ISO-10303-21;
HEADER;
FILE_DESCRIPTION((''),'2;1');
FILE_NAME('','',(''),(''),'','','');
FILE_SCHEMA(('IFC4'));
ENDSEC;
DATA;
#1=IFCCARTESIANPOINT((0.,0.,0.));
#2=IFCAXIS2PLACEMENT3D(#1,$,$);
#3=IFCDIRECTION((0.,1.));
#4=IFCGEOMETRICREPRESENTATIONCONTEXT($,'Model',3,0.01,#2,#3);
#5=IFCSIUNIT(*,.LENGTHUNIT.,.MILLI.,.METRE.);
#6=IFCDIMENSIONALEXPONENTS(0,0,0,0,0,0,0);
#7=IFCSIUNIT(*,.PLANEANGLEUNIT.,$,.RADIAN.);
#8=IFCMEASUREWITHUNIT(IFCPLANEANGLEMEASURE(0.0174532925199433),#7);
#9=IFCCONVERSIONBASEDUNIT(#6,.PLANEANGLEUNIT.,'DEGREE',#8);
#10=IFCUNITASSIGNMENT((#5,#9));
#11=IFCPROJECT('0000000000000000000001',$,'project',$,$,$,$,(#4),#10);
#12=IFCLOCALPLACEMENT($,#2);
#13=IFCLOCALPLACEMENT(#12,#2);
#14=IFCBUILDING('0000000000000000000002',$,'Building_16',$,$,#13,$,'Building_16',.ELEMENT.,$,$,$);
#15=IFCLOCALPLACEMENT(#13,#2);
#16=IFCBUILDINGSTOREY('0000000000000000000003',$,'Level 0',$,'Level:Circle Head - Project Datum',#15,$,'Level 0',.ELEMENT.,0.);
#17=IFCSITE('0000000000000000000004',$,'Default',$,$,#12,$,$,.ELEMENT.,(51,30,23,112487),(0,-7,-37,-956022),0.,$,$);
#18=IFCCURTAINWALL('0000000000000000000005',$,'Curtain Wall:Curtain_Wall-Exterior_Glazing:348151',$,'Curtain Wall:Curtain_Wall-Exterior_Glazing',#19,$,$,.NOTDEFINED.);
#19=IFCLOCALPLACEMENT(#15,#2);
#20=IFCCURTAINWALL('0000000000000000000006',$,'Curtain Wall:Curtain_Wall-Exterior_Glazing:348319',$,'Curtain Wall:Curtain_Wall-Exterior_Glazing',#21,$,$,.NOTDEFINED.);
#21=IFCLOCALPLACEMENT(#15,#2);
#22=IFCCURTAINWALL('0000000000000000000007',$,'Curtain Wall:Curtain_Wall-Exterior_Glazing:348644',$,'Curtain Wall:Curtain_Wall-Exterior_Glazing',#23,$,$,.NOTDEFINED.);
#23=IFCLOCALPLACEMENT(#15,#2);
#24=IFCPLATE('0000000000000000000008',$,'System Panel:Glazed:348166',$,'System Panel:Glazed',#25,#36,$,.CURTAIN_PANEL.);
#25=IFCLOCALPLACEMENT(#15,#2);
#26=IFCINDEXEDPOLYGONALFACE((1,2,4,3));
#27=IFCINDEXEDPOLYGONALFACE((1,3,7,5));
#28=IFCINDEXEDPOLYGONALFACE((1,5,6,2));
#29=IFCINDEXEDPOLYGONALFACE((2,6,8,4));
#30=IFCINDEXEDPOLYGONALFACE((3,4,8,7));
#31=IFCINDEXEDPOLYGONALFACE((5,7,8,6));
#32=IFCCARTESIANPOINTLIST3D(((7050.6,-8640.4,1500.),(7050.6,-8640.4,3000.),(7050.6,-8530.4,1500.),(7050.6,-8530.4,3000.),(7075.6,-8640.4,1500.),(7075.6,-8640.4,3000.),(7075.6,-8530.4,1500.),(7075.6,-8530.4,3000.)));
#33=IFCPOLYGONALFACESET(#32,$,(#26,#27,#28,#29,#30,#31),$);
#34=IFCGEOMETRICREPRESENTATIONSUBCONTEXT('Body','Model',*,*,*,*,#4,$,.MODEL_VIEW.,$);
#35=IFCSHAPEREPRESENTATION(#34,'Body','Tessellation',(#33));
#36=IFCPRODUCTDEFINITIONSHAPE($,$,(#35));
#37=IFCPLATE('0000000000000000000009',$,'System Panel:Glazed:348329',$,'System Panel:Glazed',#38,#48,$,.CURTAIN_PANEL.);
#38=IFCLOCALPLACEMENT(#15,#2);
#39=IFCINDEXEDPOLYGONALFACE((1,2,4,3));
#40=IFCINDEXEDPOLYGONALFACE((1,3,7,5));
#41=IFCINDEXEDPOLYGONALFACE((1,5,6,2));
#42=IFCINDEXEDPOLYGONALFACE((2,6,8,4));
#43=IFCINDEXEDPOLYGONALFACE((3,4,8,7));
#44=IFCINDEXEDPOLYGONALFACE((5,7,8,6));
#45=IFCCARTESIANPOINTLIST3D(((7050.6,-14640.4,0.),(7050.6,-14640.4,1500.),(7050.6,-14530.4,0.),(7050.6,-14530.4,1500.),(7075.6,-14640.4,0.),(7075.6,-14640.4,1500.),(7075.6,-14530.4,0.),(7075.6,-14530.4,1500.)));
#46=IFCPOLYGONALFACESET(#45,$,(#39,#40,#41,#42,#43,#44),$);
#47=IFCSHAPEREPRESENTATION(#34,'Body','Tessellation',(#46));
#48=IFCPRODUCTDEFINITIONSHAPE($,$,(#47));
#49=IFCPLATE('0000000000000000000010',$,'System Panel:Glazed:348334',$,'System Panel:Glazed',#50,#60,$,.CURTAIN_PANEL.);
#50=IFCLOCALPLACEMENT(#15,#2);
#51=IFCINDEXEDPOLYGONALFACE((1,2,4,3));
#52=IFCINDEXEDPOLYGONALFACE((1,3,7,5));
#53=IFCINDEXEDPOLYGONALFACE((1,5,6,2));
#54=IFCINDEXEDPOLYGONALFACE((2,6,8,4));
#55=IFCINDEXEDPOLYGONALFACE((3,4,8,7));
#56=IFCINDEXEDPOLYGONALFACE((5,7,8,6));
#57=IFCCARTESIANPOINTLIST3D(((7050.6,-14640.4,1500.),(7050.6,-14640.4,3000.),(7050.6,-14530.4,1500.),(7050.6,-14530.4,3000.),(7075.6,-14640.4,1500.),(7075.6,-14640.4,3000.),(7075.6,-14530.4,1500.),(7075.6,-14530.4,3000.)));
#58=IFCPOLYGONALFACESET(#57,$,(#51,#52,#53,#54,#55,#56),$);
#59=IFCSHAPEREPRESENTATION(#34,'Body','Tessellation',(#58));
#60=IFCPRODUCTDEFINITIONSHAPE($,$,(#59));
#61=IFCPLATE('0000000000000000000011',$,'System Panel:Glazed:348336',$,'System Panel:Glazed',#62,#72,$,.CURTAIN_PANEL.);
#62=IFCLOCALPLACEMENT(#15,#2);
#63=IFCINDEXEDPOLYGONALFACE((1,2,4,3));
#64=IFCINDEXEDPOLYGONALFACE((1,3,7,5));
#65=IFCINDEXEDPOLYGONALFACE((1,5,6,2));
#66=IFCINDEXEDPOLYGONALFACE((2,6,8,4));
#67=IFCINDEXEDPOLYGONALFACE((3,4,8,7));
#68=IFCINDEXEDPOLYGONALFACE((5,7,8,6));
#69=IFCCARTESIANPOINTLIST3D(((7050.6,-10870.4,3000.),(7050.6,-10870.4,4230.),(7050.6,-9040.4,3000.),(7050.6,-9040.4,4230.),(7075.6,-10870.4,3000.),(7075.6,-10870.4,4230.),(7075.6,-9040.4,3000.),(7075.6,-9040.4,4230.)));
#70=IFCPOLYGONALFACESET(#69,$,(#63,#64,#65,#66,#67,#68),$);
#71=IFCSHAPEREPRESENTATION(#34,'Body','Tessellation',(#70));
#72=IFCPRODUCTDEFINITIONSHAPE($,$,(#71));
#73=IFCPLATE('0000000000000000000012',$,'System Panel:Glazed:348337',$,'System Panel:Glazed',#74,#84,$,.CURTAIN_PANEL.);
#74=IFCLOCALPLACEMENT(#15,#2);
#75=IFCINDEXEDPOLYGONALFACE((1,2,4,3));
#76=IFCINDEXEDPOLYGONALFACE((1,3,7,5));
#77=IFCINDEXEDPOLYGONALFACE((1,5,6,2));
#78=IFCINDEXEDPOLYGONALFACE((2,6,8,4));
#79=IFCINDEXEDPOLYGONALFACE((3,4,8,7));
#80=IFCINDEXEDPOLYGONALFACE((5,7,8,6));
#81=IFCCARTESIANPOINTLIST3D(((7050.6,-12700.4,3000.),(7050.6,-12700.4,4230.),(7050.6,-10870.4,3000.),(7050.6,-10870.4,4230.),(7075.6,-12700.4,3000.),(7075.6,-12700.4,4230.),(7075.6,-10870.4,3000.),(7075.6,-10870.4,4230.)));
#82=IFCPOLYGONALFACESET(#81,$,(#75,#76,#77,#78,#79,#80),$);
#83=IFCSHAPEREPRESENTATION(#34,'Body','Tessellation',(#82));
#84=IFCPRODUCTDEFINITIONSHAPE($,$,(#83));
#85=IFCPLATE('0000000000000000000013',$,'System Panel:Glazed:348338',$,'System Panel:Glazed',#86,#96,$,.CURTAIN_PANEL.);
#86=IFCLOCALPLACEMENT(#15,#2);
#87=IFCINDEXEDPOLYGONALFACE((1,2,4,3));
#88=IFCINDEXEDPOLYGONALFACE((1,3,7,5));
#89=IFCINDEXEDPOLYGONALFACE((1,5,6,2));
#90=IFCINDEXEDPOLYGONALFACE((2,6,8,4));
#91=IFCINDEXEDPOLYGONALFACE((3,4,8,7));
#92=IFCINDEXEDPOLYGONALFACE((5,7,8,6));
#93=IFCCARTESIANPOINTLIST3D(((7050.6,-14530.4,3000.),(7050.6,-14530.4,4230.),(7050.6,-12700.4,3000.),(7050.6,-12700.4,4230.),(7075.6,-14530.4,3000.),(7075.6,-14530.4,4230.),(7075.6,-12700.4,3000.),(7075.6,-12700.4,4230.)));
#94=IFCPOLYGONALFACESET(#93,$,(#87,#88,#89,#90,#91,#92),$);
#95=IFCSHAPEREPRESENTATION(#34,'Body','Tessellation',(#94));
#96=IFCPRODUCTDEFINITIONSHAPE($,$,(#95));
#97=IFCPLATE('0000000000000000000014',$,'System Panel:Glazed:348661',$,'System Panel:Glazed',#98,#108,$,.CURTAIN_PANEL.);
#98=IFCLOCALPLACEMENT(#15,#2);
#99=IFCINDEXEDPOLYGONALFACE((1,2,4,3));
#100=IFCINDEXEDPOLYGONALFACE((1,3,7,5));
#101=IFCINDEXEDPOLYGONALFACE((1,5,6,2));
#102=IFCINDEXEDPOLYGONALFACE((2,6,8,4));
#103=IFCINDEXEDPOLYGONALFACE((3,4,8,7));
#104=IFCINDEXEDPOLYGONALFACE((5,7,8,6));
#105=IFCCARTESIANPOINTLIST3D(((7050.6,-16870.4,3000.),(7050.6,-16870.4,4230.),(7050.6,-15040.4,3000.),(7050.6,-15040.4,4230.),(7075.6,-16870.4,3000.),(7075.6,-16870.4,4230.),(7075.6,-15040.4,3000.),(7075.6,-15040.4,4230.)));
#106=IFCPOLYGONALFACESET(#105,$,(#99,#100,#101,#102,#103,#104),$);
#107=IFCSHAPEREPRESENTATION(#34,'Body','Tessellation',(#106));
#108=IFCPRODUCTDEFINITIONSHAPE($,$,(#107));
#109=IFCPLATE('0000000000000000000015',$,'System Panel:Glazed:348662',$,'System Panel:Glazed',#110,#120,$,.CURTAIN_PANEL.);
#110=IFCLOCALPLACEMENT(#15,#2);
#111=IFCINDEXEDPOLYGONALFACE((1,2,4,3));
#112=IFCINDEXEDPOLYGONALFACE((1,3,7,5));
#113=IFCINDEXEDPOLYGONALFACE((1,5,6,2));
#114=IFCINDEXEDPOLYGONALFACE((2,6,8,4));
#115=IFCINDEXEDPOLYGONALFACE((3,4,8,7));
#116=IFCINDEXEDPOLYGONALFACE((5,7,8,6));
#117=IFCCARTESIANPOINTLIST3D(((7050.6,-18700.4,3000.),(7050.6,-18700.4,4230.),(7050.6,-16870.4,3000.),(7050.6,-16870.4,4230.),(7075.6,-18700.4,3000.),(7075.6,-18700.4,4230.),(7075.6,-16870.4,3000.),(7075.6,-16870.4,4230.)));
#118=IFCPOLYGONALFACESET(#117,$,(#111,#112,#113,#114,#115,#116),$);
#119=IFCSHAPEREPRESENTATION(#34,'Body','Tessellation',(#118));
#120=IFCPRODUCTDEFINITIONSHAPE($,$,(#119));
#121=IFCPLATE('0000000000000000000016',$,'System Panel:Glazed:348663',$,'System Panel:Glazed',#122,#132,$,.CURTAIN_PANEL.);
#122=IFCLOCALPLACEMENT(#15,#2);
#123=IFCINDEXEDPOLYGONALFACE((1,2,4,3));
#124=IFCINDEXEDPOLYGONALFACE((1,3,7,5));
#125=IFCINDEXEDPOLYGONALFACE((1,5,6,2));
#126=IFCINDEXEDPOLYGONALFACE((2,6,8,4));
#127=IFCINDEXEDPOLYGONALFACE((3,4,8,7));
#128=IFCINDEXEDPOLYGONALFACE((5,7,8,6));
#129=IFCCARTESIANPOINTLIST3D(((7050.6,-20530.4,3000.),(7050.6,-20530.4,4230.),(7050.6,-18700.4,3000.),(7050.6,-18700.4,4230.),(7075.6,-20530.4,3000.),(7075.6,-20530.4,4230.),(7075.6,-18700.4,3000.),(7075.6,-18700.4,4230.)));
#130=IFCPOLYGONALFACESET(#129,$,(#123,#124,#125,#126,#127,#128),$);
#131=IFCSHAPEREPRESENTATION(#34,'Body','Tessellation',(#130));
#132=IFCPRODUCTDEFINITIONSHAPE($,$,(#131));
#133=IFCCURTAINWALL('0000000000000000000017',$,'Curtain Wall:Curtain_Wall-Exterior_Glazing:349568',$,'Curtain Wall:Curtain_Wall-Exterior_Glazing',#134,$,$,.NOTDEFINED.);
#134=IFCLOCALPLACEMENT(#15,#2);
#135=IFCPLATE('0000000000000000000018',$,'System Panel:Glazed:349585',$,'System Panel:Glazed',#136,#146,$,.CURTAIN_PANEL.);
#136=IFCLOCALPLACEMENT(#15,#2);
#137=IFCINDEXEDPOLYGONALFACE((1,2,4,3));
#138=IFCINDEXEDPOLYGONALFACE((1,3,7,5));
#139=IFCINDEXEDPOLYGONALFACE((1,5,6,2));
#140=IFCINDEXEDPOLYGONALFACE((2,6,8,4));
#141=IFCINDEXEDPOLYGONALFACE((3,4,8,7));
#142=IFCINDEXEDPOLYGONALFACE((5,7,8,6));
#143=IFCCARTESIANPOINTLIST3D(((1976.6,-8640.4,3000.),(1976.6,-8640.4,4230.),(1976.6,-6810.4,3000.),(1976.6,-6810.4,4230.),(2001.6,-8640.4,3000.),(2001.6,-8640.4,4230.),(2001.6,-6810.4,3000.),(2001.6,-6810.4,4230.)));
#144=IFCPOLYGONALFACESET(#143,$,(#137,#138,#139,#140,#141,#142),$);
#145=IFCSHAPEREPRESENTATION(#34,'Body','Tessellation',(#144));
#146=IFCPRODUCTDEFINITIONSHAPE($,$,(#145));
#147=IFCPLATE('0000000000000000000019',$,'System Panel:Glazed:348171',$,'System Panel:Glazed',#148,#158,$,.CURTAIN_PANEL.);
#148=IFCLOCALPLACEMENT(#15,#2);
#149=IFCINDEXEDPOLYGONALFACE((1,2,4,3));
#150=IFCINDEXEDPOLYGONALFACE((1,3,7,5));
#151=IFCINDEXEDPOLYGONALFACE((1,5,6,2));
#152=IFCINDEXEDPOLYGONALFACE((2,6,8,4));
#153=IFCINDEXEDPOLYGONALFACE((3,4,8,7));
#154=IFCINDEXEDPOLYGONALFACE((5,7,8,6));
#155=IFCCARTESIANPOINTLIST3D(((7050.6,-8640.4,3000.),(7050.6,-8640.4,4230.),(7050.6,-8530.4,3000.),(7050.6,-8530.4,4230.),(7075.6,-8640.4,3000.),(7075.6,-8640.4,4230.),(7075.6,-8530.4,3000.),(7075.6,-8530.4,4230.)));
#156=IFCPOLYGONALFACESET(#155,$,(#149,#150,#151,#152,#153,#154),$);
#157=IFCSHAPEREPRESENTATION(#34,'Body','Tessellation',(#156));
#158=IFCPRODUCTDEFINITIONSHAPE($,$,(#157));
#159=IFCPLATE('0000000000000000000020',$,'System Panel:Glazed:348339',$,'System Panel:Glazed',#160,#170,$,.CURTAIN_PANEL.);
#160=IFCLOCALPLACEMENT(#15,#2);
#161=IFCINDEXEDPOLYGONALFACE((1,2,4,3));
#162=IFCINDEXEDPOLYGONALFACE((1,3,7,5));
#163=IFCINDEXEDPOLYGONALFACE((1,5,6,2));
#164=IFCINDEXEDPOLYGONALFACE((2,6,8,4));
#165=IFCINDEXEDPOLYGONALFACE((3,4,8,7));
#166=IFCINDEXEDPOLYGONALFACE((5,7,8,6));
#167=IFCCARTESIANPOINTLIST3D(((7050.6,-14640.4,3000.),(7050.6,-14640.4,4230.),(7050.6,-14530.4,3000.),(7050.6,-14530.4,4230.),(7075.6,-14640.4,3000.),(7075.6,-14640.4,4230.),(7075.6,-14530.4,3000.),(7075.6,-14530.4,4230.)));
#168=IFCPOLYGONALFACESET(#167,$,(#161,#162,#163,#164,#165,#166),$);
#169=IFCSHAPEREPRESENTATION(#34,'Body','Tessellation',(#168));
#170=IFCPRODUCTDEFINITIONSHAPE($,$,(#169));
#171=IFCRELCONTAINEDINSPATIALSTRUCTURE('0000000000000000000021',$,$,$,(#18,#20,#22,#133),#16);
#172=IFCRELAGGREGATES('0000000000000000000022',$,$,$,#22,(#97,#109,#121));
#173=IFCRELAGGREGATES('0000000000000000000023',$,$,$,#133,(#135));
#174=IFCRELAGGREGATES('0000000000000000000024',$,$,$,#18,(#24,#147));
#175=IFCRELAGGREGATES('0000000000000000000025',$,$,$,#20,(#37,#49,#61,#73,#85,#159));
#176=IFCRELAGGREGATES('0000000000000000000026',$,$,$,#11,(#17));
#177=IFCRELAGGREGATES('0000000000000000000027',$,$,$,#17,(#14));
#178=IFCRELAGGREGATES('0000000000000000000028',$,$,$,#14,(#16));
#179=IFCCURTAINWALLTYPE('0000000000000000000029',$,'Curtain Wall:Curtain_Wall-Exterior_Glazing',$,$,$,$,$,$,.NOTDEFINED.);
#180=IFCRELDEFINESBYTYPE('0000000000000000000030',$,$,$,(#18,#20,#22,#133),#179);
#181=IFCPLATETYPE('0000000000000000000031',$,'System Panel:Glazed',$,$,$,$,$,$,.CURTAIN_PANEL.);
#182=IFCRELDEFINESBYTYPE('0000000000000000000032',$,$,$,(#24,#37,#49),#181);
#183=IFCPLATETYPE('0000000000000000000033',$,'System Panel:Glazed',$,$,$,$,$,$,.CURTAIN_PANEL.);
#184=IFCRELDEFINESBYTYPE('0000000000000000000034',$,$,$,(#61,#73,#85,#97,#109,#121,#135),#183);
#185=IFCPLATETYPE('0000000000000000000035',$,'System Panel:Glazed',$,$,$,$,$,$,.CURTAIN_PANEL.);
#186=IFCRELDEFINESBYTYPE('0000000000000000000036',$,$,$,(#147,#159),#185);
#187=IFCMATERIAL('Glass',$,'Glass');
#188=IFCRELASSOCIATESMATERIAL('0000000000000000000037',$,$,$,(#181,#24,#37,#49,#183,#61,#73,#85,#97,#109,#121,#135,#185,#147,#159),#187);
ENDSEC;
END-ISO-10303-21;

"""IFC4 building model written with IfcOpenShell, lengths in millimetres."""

from ifc_helpers import new_model, entity, si_unit, converted_unit, direction, frame, origin, place, context, subcontext, project, spatial, indexed_curve, outline, extrude, source, transform, mapped, material, type_object, type_shapes, element, aggregate, save


model = new_model("IFC4")

# Units and contexts
model_context = context("Model", 3, precision=0.01, world=origin(), true_north=direction((0.0, 1.0)))
body_context = subcontext(model_context, "Body", "Model", "MODEL_VIEW")
ifc_project = project(units=[si_unit("LENGTHUNIT", "METRE", prefix="MILLI"), converted_unit("PLANEANGLEUNIT", "DEGREE", entity("IfcPlaneAngleMeasure", 0.0174532925199433), si_unit("PLANEANGLEUNIT", "RADIAN"), dimensions=[0, 0, 0, 0, 0, 0, 0])], contexts=[model_context])

# Site, building, storey
site_placement = place(None, origin())
site = spatial("IfcSite", under=ifc_project, at=site_placement, Name="Default", CompositionType="ELEMENT", RefLatitude=(51, 30, 23, 112487), RefLongitude=(0, -7, -37, -956022), RefElevation=0.0)
building_placement = place(site_placement, origin())
building = spatial("IfcBuilding", under=site, at=building_placement, Name="Building_16", LongName="Building_16", CompositionType="ELEMENT")
storey_placement = place(building_placement, origin())
storey = spatial("IfcBuildingStorey", under=building, at=storey_placement, Name="Level 0", ObjectType="Level:Circle Head - Project Datum", LongName="Level 0", CompositionType="ELEMENT", Elevation=0.0)

# Curtain walls
curtain_wall_type = type_object("IfcCurtainWallType", Name="Curtain Wall:Curtain_Wall-Exterior_Glazing", PredefinedType="NOTDEFINED")
curtain_wall_1_placement = place(storey_placement, origin())
curtain_wall_1 = element("IfcCurtainWall", 1, at=curtain_wall_1_placement, inside=storey, type_object=curtain_wall_type, Name="Curtain Wall:Curtain_Wall-Exterior_Glazing:348151", ObjectType="Curtain Wall:Curtain_Wall-Exterior_Glazing", PredefinedType="NOTDEFINED")
ifc_material_1 = material(Name="Glass", Category="Glass")
curtain_wall_2_placement = place(storey_placement, origin())
curtain_wall_2 = element("IfcCurtainWall", 2, at=curtain_wall_2_placement, inside=storey, type_object=curtain_wall_type, Name="Curtain Wall:Curtain_Wall-Exterior_Glazing:348319", ObjectType="Curtain Wall:Curtain_Wall-Exterior_Glazing", PredefinedType="NOTDEFINED")
curtain_wall_3_placement = place(storey_placement, origin())
curtain_wall_3 = element("IfcCurtainWall", 3, at=curtain_wall_3_placement, inside=storey, type_object=curtain_wall_type, Name="Curtain Wall:Curtain_Wall-Exterior_Glazing:348644", ObjectType="Curtain Wall:Curtain_Wall-Exterior_Glazing", PredefinedType="NOTDEFINED")

# Plates
plate_type_1 = type_object("IfcPlateType", Name="System Panel:Glazed", PredefinedType="CURTAIN_PANEL", material=ifc_material_1)
shared_shape_1 = source(origin(), body_context, "Body", "SweptSolid", [
    extrude(outline(indexed_curve([(-12.5, -55.0), (12.5, -55.0), (12.5, 55.0), (-12.5, 55.0), (-12.5, -55.0)], self_intersect=False)), frame((0.0, 37.0, 0.0), z_axis=(0.0, 0.0, 1.0), x_axis=(0.0, 1.0, 0.0)), (0.0, 0.0, 1.0), 1500.0),
])
type_shapes(plate_type_1, [shared_shape_1])
plate_1_placement = place(curtain_wall_1_placement, frame((7026.1, -8585.4, 1500.0), z_axis=(0.0, 0.0, 1.0), x_axis=(0.0, -1.0, 0.0)))
plate_1 = element("IfcPlate", 4, at=plate_1_placement, type_object=plate_type_1, material=ifc_material_1, Name="System Panel:Glazed:348166", ObjectType="System Panel:Glazed", PredefinedType="CURTAIN_PANEL", context=body_context, shape_type="MappedRepresentation", body=[
    mapped(shared_shape_1, transform((0.0, 0.0, 0.0), scale=1.0)),
])
plate_2_placement = place(curtain_wall_2_placement, frame((7026.1, -14585.4, 0.0), z_axis=(0.0, 0.0, 1.0), x_axis=(0.0, -1.0, 0.0)))
plate_2 = element("IfcPlate", 5, at=plate_2_placement, type_object=plate_type_1, material=ifc_material_1, Name="System Panel:Glazed:348329", ObjectType="System Panel:Glazed", PredefinedType="CURTAIN_PANEL", context=body_context, shape_type="MappedRepresentation", body=[
    mapped(shared_shape_1, transform((0.0, 0.0, 0.0), scale=1.0)),
])
plate_3_placement = place(curtain_wall_2_placement, frame((7026.1, -14585.4, 1500.0), z_axis=(0.0, 0.0, 1.0), x_axis=(0.0, -1.0, 0.0)))
plate_3 = element("IfcPlate", 6, at=plate_3_placement, type_object=plate_type_1, material=ifc_material_1, Name="System Panel:Glazed:348334", ObjectType="System Panel:Glazed", PredefinedType="CURTAIN_PANEL", context=body_context, shape_type="MappedRepresentation", body=[
    mapped(shared_shape_1, transform((0.0, 0.0, 0.0), scale=1.0)),
])
plate_type_2 = type_object("IfcPlateType", Name="System Panel:Glazed", PredefinedType="CURTAIN_PANEL", material=ifc_material_1)
shared_shape_2 = source(origin(), body_context, "Body", "SweptSolid", [
    extrude(outline(indexed_curve([(-12.5, -915.0), (12.5, -915.0), (12.5, 915.0), (-12.5, 915.0), (-12.5, -915.0)], self_intersect=False)), frame((0.0, 37.0, 0.0), z_axis=(0.0, 0.0, 1.0), x_axis=(0.0, 1.0, 0.0)), (0.0, 0.0, 1.0), 1230.0),
])
type_shapes(plate_type_2, [shared_shape_2])
plate_4_placement = place(curtain_wall_2_placement, frame((7026.1, -9955.4, 3000.0), z_axis=(0.0, 0.0, 1.0), x_axis=(0.0, -1.0, 0.0)))
plate_4 = element("IfcPlate", 7, at=plate_4_placement, type_object=plate_type_2, material=ifc_material_1, Name="System Panel:Glazed:348336", ObjectType="System Panel:Glazed", PredefinedType="CURTAIN_PANEL", context=body_context, shape_type="MappedRepresentation", body=[
    mapped(shared_shape_2, transform((0.0, 0.0, 0.0), scale=1.0)),
])
plate_5_placement = place(curtain_wall_2_placement, frame((7026.1, -11785.4, 3000.0), z_axis=(0.0, 0.0, 1.0), x_axis=(0.0, -1.0, 0.0)))
plate_5 = element("IfcPlate", 8, at=plate_5_placement, type_object=plate_type_2, material=ifc_material_1, Name="System Panel:Glazed:348337", ObjectType="System Panel:Glazed", PredefinedType="CURTAIN_PANEL", context=body_context, shape_type="MappedRepresentation", body=[
    mapped(shared_shape_2, transform((0.0, 0.0, 0.0), scale=1.0)),
])
plate_6_placement = place(curtain_wall_2_placement, frame((7026.1, -13615.4, 3000.0), z_axis=(0.0, 0.0, 1.0), x_axis=(0.0, -1.0, 0.0)))
plate_6 = element("IfcPlate", 9, at=plate_6_placement, type_object=plate_type_2, material=ifc_material_1, Name="System Panel:Glazed:348338", ObjectType="System Panel:Glazed", PredefinedType="CURTAIN_PANEL", context=body_context, shape_type="MappedRepresentation", body=[
    mapped(shared_shape_2, transform((0.0, 0.0, 0.0), scale=1.0)),
])
plate_7_placement = place(curtain_wall_3_placement, frame((7026.1, -15955.4, 3000.0), z_axis=(0.0, 0.0, 1.0), x_axis=(0.0, -1.0, 0.0)))
plate_7 = element("IfcPlate", 10, at=plate_7_placement, type_object=plate_type_2, material=ifc_material_1, Name="System Panel:Glazed:348661", ObjectType="System Panel:Glazed", PredefinedType="CURTAIN_PANEL", context=body_context, shape_type="MappedRepresentation", body=[
    mapped(shared_shape_2, transform((0.0, 0.0, 0.0), scale=1.0)),
])
plate_8_placement = place(curtain_wall_3_placement, frame((7026.1, -17785.4, 3000.0), z_axis=(0.0, 0.0, 1.0), x_axis=(0.0, -1.0, 0.0)))
plate_8 = element("IfcPlate", 11, at=plate_8_placement, type_object=plate_type_2, material=ifc_material_1, Name="System Panel:Glazed:348662", ObjectType="System Panel:Glazed", PredefinedType="CURTAIN_PANEL", context=body_context, shape_type="MappedRepresentation", body=[
    mapped(shared_shape_2, transform((0.0, 0.0, 0.0), scale=1.0)),
])
plate_9_placement = place(curtain_wall_3_placement, frame((7026.1, -19615.4, 3000.0), z_axis=(0.0, 0.0, 1.0), x_axis=(0.0, -1.0, 0.0)))
plate_9 = element("IfcPlate", 12, at=plate_9_placement, type_object=plate_type_2, material=ifc_material_1, Name="System Panel:Glazed:348663", ObjectType="System Panel:Glazed", PredefinedType="CURTAIN_PANEL", context=body_context, shape_type="MappedRepresentation", body=[
    mapped(shared_shape_2, transform((0.0, 0.0, 0.0), scale=1.0)),
])
aggregate(curtain_wall_3, [plate_7, plate_8, plate_9])

# Curtain wall, plate
curtain_wall_4_placement = place(storey_placement, origin())
curtain_wall_4 = element("IfcCurtainWall", 13, at=curtain_wall_4_placement, inside=storey, type_object=curtain_wall_type, Name="Curtain Wall:Curtain_Wall-Exterior_Glazing:349568", ObjectType="Curtain Wall:Curtain_Wall-Exterior_Glazing", PredefinedType="NOTDEFINED")
plate_10_placement = place(curtain_wall_4_placement, frame((2026.1, -7725.4, 3000.0), z_axis=(0.0, 0.0, 1.0), x_axis=(0.0, 1.0, 0.0)))
plate_10 = element("IfcPlate", 14, at=plate_10_placement, type_object=plate_type_2, material=ifc_material_1, Name="System Panel:Glazed:349585", ObjectType="System Panel:Glazed", PredefinedType="CURTAIN_PANEL", context=body_context, shape_type="MappedRepresentation", body=[
    mapped(shared_shape_2, transform((0.0, 0.0, 0.0), scale=1.0)),
])
aggregate(curtain_wall_4, [plate_10])

# Plates
plate_type_3 = type_object("IfcPlateType", Name="System Panel:Glazed", PredefinedType="CURTAIN_PANEL", material=ifc_material_1)
shared_shape_3 = source(origin(), body_context, "Body", "SweptSolid", [
    extrude(outline(indexed_curve([(-12.5, -55.0), (12.5, -55.0), (12.5, 55.0), (-12.5, 55.0), (-12.5, -55.0)], self_intersect=False)), frame((0.0, 37.0, 0.0), z_axis=(0.0, 0.0, 1.0), x_axis=(0.0, 1.0, 0.0)), (0.0, 0.0, 1.0), 1230.0),
])
type_shapes(plate_type_3, [shared_shape_3])
plate_11_placement = place(curtain_wall_1_placement, frame((7026.1, -8585.4, 3000.0), z_axis=(0.0, 0.0, 1.0), x_axis=(0.0, -1.0, 0.0)))
plate_11 = element("IfcPlate", 15, at=plate_11_placement, type_object=plate_type_3, material=ifc_material_1, Name="System Panel:Glazed:348171", ObjectType="System Panel:Glazed", PredefinedType="CURTAIN_PANEL", context=body_context, shape_type="MappedRepresentation", body=[
    mapped(shared_shape_3, transform((0.0, 0.0, 0.0), scale=1.0)),
])
aggregate(curtain_wall_1, [plate_1, plate_11])
plate_12_placement = place(curtain_wall_2_placement, frame((7026.1, -14585.4, 3000.0), z_axis=(0.0, 0.0, 1.0), x_axis=(0.0, -1.0, 0.0)))
plate_12 = element("IfcPlate", 16, at=plate_12_placement, type_object=plate_type_3, material=ifc_material_1, Name="System Panel:Glazed:348339", ObjectType="System Panel:Glazed", PredefinedType="CURTAIN_PANEL", context=body_context, shape_type="MappedRepresentation", body=[
    mapped(shared_shape_3, transform((0.0, 0.0, 0.0), scale=1.0)),
])
aggregate(curtain_wall_2, [plate_2, plate_3, plate_4, plate_5, plate_6, plate_12])

save(model, "model.ifc")
